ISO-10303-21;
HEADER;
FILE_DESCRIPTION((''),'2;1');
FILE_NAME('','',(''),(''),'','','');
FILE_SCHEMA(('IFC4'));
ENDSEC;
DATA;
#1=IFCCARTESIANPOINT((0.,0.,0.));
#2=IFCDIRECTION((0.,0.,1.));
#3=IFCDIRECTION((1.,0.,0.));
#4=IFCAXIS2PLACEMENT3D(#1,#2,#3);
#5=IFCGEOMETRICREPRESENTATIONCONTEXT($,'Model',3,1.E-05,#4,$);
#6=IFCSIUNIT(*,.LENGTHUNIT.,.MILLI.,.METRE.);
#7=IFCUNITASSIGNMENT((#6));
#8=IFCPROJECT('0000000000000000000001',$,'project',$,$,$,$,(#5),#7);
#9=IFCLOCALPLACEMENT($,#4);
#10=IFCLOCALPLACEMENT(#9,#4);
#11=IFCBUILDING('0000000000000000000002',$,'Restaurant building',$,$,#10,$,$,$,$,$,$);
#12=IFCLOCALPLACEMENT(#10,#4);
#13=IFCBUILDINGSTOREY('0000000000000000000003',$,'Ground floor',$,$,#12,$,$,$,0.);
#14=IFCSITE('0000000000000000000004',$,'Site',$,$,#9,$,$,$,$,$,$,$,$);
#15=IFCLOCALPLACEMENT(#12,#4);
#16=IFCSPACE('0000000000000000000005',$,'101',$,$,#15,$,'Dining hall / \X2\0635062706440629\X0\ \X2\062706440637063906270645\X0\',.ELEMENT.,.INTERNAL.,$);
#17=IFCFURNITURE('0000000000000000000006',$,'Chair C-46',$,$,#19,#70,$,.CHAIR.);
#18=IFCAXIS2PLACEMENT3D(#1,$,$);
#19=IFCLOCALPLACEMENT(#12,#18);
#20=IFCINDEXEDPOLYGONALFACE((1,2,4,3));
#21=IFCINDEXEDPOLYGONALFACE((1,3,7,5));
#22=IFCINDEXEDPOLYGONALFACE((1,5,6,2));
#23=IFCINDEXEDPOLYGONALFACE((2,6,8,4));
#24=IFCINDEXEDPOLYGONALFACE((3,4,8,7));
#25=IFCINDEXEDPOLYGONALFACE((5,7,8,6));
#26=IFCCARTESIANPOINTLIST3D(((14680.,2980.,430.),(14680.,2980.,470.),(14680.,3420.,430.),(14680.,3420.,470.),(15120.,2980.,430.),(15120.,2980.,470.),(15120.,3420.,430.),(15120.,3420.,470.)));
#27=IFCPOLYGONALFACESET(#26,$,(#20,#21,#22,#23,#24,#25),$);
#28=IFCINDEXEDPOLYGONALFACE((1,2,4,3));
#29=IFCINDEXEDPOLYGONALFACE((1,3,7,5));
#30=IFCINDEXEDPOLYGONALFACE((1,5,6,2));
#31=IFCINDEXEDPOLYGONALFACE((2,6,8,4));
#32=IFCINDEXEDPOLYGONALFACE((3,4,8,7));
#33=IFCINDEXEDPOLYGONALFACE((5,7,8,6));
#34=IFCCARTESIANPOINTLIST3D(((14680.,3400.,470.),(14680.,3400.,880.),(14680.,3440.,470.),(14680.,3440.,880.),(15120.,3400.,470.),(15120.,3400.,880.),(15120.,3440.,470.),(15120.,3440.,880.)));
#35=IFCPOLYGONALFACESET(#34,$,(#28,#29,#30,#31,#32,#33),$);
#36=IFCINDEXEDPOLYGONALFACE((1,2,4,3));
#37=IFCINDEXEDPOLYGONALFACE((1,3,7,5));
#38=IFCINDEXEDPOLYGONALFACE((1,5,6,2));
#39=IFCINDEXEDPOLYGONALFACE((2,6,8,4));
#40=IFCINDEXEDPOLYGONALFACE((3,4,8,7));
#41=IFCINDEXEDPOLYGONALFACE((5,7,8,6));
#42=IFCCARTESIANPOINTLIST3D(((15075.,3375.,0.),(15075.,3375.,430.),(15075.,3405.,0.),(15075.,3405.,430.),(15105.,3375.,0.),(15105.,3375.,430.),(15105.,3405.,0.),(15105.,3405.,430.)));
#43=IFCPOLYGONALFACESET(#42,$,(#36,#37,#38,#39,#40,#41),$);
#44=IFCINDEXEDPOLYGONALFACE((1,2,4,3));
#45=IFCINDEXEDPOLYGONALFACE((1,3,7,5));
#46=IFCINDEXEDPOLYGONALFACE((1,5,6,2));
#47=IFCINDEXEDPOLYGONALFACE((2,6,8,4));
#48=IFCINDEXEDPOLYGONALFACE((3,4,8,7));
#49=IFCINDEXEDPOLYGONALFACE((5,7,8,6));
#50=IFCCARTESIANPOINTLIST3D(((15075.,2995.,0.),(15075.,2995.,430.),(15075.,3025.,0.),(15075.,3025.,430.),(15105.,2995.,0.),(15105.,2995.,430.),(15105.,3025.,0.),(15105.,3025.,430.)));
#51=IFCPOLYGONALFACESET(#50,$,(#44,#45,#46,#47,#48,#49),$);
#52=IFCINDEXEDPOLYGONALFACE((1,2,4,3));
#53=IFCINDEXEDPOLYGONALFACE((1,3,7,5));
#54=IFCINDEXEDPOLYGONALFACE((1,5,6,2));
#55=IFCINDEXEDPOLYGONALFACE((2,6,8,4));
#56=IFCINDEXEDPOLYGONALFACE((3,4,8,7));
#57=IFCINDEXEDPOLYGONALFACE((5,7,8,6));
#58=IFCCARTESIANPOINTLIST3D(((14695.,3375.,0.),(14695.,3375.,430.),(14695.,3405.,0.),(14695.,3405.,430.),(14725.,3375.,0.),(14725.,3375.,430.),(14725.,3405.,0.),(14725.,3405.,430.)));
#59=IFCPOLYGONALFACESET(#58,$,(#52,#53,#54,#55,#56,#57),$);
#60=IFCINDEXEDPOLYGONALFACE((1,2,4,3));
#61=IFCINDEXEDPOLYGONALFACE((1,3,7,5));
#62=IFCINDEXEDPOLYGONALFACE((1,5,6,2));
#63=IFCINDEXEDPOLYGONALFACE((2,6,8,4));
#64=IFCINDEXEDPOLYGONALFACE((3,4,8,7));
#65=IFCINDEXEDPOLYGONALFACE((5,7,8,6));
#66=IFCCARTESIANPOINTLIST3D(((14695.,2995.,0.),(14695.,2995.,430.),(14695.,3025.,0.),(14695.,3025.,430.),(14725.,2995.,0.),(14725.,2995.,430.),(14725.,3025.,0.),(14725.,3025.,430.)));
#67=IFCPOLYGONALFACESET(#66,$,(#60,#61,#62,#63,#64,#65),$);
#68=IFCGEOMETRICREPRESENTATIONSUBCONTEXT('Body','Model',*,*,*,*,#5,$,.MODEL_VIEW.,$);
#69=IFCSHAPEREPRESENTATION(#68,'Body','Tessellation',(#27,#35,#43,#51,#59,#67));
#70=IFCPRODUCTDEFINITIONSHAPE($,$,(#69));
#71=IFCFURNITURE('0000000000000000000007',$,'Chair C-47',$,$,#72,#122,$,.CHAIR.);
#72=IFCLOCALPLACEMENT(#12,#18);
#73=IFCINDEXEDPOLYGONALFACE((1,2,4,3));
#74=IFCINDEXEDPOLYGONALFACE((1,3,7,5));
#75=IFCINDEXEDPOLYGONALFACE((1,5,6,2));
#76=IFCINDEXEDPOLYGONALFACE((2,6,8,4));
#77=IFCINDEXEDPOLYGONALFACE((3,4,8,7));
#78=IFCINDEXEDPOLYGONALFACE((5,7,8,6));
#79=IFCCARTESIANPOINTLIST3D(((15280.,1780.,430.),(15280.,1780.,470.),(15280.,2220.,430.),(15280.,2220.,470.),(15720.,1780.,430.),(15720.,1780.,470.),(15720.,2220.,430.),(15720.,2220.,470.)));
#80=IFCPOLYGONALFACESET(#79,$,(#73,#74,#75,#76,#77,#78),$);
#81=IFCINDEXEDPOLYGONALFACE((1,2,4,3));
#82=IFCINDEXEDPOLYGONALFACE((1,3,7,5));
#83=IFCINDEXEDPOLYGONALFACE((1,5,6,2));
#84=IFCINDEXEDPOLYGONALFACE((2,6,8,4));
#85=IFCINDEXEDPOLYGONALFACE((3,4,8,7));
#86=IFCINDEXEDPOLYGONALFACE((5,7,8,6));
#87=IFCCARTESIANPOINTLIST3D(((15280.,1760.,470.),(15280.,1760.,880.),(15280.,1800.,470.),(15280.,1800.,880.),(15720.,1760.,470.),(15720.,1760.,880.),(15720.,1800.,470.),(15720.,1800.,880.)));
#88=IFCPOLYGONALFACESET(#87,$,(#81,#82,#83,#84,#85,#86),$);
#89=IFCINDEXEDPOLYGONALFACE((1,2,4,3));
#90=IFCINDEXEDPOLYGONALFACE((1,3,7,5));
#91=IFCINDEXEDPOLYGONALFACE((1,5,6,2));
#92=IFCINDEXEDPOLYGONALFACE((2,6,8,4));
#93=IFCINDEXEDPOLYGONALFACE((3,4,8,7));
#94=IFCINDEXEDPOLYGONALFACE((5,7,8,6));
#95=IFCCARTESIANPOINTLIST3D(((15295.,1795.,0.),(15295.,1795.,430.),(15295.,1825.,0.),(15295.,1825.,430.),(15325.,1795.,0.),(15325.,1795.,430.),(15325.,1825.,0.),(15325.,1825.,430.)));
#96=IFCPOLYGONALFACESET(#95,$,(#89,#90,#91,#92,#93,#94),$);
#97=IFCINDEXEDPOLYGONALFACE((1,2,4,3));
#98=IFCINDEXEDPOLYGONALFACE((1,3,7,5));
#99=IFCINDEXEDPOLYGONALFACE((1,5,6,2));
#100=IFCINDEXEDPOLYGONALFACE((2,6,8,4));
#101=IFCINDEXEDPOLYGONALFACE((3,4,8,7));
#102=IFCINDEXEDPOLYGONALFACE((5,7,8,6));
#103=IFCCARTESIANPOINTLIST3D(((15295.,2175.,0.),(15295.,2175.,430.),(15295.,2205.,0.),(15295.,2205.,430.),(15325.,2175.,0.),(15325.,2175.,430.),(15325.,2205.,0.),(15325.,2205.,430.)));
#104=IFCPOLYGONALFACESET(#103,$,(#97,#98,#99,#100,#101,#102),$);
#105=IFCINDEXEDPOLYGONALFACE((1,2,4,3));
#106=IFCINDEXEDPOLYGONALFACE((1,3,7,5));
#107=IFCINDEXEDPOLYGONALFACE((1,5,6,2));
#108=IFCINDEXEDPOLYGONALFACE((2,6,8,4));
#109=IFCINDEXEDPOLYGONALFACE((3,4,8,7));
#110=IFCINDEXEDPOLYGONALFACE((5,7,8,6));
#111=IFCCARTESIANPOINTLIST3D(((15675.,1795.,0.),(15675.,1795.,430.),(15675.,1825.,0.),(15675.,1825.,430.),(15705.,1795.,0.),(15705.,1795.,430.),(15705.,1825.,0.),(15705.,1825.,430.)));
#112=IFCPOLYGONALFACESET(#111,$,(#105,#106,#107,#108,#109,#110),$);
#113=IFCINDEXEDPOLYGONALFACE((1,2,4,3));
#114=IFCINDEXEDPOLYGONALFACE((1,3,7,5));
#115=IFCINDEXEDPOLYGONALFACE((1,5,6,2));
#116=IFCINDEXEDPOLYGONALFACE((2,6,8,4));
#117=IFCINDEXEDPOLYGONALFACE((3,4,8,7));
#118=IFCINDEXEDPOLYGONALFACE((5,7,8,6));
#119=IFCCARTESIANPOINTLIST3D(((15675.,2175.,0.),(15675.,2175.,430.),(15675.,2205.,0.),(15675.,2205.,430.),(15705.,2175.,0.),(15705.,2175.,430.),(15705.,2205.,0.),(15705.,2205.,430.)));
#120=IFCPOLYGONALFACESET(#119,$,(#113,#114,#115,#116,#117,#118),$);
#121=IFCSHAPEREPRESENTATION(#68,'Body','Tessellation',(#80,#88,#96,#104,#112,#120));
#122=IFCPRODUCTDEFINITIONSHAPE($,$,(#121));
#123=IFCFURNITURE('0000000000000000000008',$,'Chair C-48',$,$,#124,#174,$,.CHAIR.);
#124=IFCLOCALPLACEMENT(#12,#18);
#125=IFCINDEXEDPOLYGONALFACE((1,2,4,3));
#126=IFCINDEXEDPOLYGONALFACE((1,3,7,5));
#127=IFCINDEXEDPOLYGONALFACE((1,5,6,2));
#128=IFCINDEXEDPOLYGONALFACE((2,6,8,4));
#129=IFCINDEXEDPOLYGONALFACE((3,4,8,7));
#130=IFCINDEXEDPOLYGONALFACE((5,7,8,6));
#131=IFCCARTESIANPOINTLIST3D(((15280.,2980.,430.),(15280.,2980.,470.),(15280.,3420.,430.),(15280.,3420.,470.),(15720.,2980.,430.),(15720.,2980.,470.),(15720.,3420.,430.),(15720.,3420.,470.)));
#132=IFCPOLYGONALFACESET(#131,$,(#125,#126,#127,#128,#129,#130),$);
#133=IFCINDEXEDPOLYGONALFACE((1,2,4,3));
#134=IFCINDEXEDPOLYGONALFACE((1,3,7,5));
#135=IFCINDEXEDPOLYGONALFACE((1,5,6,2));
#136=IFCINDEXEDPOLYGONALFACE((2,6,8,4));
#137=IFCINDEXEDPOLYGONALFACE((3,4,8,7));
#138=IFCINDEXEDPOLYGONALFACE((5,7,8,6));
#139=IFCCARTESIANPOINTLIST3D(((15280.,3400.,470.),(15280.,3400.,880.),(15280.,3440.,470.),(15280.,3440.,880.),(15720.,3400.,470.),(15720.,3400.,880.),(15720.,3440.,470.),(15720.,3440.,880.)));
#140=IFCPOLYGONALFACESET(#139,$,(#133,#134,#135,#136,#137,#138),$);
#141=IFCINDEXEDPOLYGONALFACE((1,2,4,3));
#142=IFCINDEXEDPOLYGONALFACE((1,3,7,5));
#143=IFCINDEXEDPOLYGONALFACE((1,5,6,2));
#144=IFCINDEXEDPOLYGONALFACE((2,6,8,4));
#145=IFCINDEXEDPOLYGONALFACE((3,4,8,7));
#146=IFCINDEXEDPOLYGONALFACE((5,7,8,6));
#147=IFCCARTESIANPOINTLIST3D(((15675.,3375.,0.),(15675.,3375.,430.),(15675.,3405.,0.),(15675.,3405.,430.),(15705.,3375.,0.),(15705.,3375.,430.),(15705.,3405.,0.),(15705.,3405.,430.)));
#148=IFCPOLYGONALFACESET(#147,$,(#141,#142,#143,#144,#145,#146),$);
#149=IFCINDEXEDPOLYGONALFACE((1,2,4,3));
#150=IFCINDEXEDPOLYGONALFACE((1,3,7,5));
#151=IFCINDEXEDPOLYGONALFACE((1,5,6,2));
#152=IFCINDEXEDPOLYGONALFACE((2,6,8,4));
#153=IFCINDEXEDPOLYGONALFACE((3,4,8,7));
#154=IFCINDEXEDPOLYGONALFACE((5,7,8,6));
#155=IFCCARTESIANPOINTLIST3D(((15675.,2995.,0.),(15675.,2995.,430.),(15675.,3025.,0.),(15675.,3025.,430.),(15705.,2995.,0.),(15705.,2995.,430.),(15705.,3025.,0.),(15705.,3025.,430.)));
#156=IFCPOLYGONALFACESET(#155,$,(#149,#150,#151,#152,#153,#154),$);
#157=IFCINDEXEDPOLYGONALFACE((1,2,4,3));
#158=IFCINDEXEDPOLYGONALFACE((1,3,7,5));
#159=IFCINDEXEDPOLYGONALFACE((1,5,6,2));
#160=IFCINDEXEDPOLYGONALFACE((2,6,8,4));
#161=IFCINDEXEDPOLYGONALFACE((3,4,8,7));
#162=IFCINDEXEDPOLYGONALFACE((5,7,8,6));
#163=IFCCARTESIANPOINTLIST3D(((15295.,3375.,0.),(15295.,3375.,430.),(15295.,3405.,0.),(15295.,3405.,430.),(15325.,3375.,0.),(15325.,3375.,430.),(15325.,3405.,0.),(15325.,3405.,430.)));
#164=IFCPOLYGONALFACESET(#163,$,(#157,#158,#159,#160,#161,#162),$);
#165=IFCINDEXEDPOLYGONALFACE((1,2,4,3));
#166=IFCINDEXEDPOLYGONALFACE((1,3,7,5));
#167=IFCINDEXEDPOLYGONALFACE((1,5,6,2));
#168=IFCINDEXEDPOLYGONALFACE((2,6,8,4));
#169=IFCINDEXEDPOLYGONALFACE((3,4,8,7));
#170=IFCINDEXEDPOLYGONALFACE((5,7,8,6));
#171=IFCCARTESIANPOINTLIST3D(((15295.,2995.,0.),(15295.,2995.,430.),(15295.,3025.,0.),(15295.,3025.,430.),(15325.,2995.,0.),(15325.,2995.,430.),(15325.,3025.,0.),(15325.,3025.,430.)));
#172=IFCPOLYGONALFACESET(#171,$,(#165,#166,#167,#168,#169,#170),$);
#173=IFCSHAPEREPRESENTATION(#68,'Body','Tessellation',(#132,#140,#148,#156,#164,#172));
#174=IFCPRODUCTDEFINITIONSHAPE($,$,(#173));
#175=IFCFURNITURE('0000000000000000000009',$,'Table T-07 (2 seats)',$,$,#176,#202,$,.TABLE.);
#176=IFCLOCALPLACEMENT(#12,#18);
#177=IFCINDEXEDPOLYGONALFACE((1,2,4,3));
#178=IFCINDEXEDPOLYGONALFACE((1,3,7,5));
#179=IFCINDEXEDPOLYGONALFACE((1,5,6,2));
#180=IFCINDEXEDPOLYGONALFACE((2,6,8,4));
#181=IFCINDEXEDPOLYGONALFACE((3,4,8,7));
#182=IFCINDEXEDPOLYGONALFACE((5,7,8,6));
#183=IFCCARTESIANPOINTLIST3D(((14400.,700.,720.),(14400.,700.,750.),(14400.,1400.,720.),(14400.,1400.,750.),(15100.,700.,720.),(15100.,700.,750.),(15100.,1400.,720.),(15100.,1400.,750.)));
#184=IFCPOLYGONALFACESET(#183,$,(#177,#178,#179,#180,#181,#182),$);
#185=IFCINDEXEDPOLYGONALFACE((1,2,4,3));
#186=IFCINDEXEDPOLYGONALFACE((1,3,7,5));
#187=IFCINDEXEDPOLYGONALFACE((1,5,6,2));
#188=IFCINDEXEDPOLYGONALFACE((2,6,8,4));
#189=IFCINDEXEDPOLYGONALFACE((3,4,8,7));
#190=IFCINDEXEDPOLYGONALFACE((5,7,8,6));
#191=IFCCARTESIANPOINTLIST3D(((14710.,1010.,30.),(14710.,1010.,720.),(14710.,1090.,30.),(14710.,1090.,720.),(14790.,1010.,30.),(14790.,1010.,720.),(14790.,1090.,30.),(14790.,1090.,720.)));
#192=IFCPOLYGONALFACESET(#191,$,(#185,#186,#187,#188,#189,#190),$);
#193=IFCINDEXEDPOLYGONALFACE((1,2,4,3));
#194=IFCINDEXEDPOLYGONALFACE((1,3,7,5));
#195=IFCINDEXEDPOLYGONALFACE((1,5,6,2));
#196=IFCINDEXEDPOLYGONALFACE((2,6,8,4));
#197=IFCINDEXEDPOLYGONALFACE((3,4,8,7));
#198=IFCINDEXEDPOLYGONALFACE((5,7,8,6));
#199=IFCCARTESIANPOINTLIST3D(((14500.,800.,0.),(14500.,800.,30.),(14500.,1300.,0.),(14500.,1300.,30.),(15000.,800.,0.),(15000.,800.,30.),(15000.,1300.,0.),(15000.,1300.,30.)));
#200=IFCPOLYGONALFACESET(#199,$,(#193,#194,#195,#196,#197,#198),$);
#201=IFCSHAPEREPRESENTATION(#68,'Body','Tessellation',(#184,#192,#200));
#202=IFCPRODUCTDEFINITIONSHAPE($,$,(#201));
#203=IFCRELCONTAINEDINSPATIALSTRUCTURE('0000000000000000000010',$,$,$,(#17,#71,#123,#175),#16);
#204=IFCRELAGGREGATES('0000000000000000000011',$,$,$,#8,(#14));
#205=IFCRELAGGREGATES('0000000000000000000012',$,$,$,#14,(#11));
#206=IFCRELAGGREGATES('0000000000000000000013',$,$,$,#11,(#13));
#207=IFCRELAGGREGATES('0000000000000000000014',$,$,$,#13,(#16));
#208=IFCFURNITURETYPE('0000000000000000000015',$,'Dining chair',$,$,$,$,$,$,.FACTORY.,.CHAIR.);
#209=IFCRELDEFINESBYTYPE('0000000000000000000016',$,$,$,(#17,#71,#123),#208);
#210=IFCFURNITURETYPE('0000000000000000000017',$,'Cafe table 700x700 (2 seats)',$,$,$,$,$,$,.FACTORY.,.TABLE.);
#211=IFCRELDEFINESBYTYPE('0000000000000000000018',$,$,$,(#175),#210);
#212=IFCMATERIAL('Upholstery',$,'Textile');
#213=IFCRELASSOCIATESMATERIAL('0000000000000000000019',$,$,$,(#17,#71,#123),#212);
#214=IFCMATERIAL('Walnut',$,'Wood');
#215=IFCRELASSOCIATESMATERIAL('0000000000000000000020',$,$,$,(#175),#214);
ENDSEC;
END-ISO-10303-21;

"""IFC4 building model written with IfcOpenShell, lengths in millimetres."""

from ifc_helpers import new_model, si_unit, frame, origin, origin_with_axes, origin_2d, place, context, subcontext, project, spatial, rectangle, extrude, source, transform, mapped, material, type_object, type_shapes, element, save


model = new_model("IFC4")

# Units and contexts
model_context = context("Model", 3, precision=1e-05, world=origin_with_axes())
body_context = subcontext(model_context, "Body", "Model", "MODEL_VIEW")
ifc_project = project(units=[si_unit("LENGTHUNIT", "METRE", prefix="MILLI")], contexts=[model_context])

# Site, building, storey
site_placement = place(None, origin_with_axes())
site = spatial("IfcSite", under=ifc_project, at=site_placement, Name="Site")
building_placement = place(site_placement, origin_with_axes())
building = spatial("IfcBuilding", under=site, at=building_placement, Name="Restaurant building")
storey_placement = place(building_placement, origin_with_axes())
storey = spatial("IfcBuildingStorey", under=building, at=storey_placement, Name="Ground floor", Elevation=0.0)

# Shared definitions
space_placement = place(storey_placement, origin_with_axes())
space = spatial("IfcSpace", under=storey, at=space_placement, Name="101", LongName="Dining hall / صالة الطعام", CompositionType="ELEMENT", PredefinedType="INTERNAL")

# Furniture
ifc_material_1 = material(Name="Upholstery", Category="Textile")
furniture_type_1 = type_object("IfcFurnitureType", Name="Dining chair", AssemblyPlace="FACTORY", PredefinedType="CHAIR")
shared_shape_1 = source(origin(), body_context, "Body", "SweptSolid", [
    extrude(rectangle(XDim=440.0, YDim=440.0, at=origin_2d()), frame((0.0, 0.0, 430.0)), (0.0, 0.0, 1.0), 40.0),
    extrude(rectangle(XDim=440.0, YDim=40.0, at=origin_2d()), frame((0.0, -220.0, 470.0)), (0.0, 0.0, 1.0), 410.0),
    extrude(rectangle(XDim=30.0, YDim=30.0, at=origin_2d()), frame((-190.0, -190.0, 0.0)), (0.0, 0.0, 1.0), 430.0),
    extrude(rectangle(XDim=30.0, YDim=30.0, at=origin_2d()), frame((-190.0, 190.0, 0.0)), (0.0, 0.0, 1.0), 430.0),
    extrude(rectangle(XDim=30.0, YDim=30.0, at=origin_2d()), frame((190.0, -190.0, 0.0)), (0.0, 0.0, 1.0), 430.0),
    extrude(rectangle(XDim=30.0, YDim=30.0, at=origin_2d()), frame((190.0, 190.0, 0.0)), (0.0, 0.0, 1.0), 430.0),
])
type_shapes(furniture_type_1, [shared_shape_1])
furniture_1_placement = place(storey_placement, frame((14900.0, 3200.0, 0.0), z_axis=(0.0, 0.0, 1.0), x_axis=(-1.0, 0.0, 0.0)))
element("IfcFurniture", 1, at=furniture_1_placement, inside=space, type_object=furniture_type_1, material=ifc_material_1, Name="Chair C-46", PredefinedType="CHAIR", context=body_context, shape_type="MappedRepresentation", body=[
    mapped(shared_shape_1, transform((0.0, 0.0, 0.0))),
])
furniture_2_placement = place(storey_placement, frame((15500.0, 2000.0, 0.0)))
element("IfcFurniture", 2, at=furniture_2_placement, inside=space, type_object=furniture_type_1, material=ifc_material_1, Name="Chair C-47", PredefinedType="CHAIR", context=body_context, shape_type="MappedRepresentation", body=[
    mapped(shared_shape_1, transform((0.0, 0.0, 0.0))),
])
furniture_3_placement = place(storey_placement, frame((15500.0, 3200.0, 0.0), z_axis=(0.0, 0.0, 1.0), x_axis=(-1.0, 0.0, 0.0)))
element("IfcFurniture", 3, at=furniture_3_placement, inside=space, type_object=furniture_type_1, material=ifc_material_1, Name="Chair C-48", PredefinedType="CHAIR", context=body_context, shape_type="MappedRepresentation", body=[
    mapped(shared_shape_1, transform((0.0, 0.0, 0.0))),
])
ifc_material_2 = material(Name="Walnut", Category="Wood")
furniture_type_2 = type_object("IfcFurnitureType", Name="Cafe table 700x700 (2 seats)", AssemblyPlace="FACTORY", PredefinedType="TABLE")
shared_shape_2 = source(origin(), body_context, "Body", "SweptSolid", [
    extrude(rectangle(XDim=700.0, YDim=700.0, at=origin_2d()), frame((0.0, 0.0, 720.0)), (0.0, 0.0, 1.0), 30.0),
    extrude(rectangle(XDim=80.0, YDim=80.0, at=origin_2d()), frame((0.0, 0.0, 30.0)), (0.0, 0.0, 1.0), 690.0),
    extrude(rectangle(XDim=500.0, YDim=500.0, at=origin_2d()), origin(), (0.0, 0.0, 1.0), 30.0),
])
type_shapes(furniture_type_2, [shared_shape_2])
furniture_4_placement = place(storey_placement, frame((14750.0, 1050.0, 0.0)))
element("IfcFurniture", 4, at=furniture_4_placement, inside=space, type_object=furniture_type_2, material=ifc_material_2, Name="Table T-07 (2 seats)", PredefinedType="TABLE", context=body_context, shape_type="MappedRepresentation", body=[
    mapped(shared_shape_2, transform((0.0, 0.0, 0.0))),
])

save(model, "model.ifc")
